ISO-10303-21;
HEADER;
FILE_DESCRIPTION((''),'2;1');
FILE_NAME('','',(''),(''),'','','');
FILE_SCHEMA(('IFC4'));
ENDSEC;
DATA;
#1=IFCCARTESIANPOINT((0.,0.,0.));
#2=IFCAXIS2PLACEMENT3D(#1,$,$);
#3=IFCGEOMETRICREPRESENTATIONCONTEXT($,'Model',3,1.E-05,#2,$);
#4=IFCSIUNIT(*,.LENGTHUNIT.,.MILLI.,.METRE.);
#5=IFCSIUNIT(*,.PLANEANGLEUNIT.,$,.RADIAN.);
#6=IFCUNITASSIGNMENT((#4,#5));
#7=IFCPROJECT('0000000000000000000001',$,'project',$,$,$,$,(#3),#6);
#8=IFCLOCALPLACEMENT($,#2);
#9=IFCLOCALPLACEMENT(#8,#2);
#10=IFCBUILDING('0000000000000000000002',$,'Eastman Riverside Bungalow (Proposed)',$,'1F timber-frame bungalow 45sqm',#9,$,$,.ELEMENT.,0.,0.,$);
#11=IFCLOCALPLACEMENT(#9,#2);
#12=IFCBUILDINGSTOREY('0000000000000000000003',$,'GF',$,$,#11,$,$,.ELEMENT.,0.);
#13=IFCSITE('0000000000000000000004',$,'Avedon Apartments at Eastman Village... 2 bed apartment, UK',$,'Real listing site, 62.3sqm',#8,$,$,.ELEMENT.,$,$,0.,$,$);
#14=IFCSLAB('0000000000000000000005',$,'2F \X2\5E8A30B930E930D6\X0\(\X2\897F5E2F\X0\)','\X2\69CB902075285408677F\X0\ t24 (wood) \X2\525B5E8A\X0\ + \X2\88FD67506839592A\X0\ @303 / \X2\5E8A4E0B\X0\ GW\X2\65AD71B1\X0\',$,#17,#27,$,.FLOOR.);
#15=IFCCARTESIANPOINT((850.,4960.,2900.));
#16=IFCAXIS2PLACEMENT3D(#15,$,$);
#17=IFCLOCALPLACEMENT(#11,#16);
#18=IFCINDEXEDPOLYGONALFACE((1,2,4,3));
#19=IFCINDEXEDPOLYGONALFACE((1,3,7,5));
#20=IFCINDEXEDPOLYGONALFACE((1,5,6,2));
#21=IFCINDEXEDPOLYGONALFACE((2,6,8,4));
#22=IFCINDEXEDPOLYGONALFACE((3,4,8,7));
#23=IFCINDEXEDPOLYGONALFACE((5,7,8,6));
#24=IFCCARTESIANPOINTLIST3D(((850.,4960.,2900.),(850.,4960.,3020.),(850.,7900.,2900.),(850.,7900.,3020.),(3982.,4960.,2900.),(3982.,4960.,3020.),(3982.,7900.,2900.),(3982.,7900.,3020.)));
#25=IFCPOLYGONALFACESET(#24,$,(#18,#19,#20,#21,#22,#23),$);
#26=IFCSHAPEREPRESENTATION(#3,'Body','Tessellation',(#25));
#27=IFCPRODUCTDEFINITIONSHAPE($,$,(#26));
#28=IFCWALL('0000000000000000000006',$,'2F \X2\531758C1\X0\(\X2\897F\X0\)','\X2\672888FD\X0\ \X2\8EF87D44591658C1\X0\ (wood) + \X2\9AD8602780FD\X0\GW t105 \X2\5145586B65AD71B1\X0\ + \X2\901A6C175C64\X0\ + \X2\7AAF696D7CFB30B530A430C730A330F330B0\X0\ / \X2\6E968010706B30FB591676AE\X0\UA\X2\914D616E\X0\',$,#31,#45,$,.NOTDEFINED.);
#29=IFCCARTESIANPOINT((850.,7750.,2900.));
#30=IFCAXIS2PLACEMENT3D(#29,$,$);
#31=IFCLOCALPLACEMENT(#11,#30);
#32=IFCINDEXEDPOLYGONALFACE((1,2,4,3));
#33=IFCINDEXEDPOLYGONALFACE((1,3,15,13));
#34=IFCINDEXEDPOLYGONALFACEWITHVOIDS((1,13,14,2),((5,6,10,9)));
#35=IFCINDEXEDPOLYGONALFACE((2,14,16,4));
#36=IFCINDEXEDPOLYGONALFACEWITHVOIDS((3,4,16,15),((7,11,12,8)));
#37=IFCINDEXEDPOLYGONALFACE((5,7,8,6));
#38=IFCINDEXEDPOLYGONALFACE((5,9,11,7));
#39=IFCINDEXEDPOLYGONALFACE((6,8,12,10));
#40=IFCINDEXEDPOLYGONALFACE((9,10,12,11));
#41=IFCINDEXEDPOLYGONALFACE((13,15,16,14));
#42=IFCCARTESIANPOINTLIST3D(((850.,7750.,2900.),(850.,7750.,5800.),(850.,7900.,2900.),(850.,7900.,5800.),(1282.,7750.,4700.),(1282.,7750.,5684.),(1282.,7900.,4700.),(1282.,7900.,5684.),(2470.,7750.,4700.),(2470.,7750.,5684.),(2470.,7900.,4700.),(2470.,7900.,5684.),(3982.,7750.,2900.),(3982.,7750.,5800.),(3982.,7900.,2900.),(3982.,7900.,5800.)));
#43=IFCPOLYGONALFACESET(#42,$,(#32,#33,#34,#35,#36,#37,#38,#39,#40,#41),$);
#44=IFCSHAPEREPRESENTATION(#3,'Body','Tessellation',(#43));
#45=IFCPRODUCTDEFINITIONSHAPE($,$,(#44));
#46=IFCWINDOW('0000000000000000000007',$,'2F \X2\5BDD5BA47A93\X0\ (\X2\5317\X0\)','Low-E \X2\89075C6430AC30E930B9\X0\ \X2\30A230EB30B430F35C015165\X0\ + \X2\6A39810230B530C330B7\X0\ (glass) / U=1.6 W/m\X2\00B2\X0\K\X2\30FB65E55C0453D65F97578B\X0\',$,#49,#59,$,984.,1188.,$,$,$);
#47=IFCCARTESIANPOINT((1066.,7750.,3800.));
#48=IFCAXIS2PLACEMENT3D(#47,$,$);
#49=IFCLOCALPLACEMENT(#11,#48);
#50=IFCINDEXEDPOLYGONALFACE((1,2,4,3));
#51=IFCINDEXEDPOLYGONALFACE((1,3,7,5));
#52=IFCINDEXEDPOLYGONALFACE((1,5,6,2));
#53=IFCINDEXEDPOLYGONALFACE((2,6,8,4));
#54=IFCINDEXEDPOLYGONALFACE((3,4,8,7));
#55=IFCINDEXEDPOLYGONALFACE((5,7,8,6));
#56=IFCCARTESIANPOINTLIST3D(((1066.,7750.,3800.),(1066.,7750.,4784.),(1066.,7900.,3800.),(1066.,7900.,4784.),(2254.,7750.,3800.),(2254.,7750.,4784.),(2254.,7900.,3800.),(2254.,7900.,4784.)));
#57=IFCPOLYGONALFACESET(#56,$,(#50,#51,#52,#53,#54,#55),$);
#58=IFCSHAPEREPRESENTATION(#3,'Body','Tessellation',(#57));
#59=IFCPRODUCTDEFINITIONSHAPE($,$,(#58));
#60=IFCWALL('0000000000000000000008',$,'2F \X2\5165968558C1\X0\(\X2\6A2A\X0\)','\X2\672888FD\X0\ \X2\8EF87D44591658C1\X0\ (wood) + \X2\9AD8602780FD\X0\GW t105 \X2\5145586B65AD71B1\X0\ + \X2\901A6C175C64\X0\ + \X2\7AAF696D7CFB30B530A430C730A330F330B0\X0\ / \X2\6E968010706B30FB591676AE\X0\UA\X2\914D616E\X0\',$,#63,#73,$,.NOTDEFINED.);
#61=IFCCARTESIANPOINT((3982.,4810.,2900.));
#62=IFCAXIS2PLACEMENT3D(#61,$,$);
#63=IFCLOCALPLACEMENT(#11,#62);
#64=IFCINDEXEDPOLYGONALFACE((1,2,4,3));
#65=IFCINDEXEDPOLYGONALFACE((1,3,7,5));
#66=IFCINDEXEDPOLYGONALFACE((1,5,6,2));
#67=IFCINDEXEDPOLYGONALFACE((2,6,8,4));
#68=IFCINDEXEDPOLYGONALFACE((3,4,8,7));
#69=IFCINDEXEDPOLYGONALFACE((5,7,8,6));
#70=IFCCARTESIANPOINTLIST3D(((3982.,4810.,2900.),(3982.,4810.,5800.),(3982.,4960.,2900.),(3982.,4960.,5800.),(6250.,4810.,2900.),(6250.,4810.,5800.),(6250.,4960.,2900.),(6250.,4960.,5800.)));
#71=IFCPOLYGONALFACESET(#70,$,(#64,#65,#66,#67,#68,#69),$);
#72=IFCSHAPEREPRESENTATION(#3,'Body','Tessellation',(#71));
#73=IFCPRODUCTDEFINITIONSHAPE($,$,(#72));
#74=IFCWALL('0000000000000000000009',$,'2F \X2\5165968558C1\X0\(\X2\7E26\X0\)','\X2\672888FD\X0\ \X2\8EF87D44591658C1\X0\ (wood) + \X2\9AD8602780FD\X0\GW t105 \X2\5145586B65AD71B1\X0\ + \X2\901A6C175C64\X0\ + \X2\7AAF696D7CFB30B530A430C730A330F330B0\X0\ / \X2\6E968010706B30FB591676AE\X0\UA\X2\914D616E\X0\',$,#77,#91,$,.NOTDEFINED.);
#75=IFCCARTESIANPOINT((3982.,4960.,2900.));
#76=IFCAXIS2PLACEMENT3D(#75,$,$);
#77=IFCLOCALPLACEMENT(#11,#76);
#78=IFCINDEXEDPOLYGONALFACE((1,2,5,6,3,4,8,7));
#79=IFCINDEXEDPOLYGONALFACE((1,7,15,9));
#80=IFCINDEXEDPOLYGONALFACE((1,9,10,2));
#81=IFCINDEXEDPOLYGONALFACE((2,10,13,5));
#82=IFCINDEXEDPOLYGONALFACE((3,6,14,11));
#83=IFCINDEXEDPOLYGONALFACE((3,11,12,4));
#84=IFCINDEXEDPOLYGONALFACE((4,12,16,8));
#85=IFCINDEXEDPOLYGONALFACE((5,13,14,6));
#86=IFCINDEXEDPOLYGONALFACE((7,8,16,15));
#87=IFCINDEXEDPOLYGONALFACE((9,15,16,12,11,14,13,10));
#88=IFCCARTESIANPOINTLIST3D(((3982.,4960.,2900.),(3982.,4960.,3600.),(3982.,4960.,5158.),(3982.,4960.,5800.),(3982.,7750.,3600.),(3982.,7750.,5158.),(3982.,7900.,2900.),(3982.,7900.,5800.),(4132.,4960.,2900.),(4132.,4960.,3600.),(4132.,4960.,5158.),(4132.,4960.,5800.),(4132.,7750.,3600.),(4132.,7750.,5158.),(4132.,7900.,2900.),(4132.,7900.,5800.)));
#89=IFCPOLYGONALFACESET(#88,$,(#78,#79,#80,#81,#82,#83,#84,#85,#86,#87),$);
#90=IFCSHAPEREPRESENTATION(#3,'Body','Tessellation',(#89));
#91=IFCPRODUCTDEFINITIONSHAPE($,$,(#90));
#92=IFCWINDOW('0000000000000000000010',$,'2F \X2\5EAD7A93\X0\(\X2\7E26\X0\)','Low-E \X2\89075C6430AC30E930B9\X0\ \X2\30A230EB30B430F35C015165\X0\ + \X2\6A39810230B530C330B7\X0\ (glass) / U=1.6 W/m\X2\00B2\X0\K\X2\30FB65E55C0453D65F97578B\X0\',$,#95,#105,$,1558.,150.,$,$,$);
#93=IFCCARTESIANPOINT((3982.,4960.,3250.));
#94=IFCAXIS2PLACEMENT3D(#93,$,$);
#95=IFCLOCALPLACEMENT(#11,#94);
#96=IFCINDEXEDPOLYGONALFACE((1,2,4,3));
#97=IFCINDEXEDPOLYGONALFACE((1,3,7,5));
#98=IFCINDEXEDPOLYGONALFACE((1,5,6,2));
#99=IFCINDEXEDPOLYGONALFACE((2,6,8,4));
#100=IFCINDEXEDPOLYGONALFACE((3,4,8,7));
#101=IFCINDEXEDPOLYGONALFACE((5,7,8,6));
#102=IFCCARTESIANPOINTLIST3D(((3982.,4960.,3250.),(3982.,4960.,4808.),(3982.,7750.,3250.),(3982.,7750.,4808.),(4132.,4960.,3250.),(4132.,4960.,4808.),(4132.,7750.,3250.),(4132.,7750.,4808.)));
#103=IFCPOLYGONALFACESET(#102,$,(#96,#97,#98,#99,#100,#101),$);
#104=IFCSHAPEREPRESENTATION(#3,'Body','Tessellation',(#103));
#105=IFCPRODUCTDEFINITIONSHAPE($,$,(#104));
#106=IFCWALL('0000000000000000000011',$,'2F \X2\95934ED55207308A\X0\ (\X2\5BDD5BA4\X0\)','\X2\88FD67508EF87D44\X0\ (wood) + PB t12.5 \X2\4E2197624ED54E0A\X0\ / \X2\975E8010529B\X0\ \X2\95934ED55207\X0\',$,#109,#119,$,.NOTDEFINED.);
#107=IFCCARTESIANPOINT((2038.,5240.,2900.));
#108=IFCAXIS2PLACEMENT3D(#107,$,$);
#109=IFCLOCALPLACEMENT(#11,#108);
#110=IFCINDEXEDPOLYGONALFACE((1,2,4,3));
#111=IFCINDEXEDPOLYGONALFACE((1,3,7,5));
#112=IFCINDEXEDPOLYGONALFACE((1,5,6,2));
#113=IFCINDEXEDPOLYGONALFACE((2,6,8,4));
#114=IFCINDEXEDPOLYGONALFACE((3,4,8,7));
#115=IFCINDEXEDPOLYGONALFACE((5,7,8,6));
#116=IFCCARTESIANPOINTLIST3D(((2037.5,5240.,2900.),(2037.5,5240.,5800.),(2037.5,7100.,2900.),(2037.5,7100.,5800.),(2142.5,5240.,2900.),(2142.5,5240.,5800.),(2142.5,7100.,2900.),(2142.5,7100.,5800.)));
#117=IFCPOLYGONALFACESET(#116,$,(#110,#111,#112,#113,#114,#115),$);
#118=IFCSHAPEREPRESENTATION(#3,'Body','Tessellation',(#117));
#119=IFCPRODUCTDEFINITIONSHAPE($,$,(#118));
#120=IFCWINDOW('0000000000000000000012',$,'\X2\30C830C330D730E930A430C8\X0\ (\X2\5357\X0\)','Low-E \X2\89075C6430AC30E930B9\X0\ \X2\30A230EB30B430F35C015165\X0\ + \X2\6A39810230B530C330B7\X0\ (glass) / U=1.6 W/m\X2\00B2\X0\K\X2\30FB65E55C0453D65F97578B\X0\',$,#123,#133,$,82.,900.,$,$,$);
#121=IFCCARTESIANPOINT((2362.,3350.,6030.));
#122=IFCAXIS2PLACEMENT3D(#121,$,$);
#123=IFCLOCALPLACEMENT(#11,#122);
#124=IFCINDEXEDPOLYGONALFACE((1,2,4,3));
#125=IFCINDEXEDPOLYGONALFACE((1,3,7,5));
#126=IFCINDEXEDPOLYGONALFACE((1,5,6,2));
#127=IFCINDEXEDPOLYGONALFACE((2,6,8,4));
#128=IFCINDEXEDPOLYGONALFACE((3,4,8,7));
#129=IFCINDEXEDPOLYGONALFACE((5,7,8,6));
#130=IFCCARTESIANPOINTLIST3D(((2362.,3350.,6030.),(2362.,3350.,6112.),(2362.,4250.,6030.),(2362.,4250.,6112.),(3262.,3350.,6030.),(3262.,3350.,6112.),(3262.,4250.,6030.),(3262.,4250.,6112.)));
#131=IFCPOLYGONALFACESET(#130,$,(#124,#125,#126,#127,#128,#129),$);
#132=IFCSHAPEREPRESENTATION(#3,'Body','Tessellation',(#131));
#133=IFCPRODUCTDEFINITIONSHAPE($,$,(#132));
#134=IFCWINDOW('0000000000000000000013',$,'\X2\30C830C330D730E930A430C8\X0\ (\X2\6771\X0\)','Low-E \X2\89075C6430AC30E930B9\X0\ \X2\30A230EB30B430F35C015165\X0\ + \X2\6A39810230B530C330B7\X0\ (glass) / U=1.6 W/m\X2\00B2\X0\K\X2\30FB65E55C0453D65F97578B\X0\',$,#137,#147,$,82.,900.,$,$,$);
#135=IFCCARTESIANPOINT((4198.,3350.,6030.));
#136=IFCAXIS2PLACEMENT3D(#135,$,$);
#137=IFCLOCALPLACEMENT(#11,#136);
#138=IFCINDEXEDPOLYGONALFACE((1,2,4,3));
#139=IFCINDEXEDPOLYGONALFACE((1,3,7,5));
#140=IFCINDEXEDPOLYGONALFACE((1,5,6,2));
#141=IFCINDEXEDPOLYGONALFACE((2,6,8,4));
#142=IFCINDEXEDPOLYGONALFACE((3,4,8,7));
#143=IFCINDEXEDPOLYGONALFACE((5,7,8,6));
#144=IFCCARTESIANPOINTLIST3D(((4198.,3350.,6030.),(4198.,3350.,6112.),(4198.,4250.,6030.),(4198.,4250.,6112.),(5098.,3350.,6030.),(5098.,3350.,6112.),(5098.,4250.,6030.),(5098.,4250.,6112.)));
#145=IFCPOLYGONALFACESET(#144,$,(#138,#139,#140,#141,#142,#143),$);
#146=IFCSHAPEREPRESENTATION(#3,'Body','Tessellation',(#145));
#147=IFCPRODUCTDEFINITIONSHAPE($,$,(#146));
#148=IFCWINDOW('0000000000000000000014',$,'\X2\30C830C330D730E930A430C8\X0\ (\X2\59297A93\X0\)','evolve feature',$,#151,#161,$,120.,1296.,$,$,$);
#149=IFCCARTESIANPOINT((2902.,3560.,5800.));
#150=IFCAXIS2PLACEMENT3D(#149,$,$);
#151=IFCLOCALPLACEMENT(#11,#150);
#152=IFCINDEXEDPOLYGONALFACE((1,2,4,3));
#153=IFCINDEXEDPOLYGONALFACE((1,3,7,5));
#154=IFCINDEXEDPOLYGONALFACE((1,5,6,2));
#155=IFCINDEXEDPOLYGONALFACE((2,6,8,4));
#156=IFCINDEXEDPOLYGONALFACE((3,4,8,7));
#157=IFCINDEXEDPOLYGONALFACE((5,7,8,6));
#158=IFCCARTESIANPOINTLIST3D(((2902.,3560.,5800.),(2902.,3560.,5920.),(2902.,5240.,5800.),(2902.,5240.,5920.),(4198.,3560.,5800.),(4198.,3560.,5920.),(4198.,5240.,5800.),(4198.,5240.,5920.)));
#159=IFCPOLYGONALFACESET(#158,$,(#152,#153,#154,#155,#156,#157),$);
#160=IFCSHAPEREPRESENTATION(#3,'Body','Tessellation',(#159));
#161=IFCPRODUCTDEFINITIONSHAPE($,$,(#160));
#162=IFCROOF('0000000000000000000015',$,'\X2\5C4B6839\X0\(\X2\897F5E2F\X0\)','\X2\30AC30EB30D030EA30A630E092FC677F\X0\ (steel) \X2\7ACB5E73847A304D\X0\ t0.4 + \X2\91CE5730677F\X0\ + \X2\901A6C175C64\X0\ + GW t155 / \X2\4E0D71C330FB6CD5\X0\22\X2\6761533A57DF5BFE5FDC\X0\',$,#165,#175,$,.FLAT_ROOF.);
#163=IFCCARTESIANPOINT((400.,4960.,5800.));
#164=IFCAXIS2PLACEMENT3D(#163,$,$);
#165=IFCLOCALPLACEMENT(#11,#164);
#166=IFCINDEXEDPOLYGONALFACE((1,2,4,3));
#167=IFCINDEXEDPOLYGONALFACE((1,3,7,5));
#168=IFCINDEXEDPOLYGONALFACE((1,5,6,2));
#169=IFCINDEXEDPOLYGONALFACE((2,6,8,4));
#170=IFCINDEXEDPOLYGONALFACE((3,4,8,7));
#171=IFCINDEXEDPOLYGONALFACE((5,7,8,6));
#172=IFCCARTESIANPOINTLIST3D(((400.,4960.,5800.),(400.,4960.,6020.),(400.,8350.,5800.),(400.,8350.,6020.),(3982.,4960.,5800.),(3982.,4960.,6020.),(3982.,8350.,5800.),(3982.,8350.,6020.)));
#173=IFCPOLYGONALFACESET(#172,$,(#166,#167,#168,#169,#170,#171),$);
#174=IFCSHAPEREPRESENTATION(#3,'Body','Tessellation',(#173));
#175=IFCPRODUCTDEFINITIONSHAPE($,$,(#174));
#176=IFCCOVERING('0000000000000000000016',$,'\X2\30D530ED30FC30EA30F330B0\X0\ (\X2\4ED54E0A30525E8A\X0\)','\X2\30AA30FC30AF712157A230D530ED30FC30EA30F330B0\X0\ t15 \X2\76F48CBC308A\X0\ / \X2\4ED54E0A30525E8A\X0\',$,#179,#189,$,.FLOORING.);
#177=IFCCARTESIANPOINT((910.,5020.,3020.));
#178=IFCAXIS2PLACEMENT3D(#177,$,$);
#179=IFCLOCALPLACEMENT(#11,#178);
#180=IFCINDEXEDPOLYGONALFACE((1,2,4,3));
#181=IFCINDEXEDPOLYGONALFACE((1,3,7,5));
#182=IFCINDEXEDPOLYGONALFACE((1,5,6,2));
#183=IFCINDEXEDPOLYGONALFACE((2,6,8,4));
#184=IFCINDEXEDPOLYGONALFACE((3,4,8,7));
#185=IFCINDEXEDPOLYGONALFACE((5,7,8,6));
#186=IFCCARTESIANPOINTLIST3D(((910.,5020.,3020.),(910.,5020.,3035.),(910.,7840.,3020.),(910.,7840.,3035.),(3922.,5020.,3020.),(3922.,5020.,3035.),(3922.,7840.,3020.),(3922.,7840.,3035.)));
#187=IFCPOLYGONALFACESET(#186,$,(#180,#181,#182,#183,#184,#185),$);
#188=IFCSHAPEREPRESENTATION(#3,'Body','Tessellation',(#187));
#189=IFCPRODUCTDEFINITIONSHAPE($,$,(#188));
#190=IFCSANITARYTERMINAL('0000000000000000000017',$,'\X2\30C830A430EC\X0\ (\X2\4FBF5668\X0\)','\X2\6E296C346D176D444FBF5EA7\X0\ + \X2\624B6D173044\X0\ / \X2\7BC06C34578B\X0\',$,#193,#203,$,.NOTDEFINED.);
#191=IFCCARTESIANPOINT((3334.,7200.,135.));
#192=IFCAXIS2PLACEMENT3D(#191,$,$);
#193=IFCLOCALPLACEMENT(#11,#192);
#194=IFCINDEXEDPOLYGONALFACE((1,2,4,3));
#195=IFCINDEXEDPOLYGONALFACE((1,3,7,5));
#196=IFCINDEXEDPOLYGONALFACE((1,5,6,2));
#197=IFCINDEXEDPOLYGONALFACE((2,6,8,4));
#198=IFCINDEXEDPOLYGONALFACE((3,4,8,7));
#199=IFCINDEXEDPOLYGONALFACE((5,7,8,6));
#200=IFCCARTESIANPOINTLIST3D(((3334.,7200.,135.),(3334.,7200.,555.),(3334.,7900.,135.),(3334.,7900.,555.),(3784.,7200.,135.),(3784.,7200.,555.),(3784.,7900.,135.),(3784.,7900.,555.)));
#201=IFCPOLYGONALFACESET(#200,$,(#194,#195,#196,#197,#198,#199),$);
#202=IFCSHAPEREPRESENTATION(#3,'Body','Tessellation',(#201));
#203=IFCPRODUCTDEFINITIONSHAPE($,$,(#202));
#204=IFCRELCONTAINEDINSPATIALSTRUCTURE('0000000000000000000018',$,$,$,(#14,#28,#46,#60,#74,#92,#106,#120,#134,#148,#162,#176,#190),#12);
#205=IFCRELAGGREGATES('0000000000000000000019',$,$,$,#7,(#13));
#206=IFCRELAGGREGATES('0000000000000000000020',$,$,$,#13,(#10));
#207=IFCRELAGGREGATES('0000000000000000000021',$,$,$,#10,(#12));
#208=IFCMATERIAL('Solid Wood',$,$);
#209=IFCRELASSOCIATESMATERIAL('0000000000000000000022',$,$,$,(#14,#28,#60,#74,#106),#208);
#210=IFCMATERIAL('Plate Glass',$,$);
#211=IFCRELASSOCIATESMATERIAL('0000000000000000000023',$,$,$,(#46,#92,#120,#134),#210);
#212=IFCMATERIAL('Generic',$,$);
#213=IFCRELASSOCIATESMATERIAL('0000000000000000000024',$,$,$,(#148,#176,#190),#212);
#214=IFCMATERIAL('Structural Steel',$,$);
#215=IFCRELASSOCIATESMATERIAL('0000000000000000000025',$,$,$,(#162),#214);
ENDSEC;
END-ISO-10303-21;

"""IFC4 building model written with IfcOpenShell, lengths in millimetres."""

from ifc_helpers import new_model, si_unit, frame, frame_2d, origin, place, context, project, spatial, rectangle, extrude, material, element, fill, save


model = new_model("IFC4")

# Units and contexts
model_context = context("Model", 3, precision=1e-05, world=origin())
ifc_project = project(units=[si_unit("LENGTHUNIT", "METRE", prefix="MILLI"), si_unit("PLANEANGLEUNIT", "RADIAN")], contexts=[model_context])

# Site, building, storey
site_placement = place(None, origin())
site = spatial("IfcSite", under=ifc_project, at=site_placement, Name="Avedon Apartments at Eastman Village... 2 bed apartment, UK", ObjectType="Real listing site, 62.3sqm", CompositionType="ELEMENT", RefElevation=0.0)
building_placement = place(site_placement, origin())
building = spatial("IfcBuilding", under=site, at=building_placement, Name="Eastman Riverside Bungalow (Proposed)", ObjectType="1F timber-frame bungalow 45sqm", CompositionType="ELEMENT", ElevationOfRefHeight=0.0, ElevationOfTerrain=0.0)
storey_placement = place(building_placement, origin())
storey = spatial("IfcBuildingStorey", under=building, at=storey_placement, Name="GF", CompositionType="ELEMENT", Elevation=0.0)

# Slab
ifc_material_1 = material(Name="Solid Wood")
slab_placement = place(storey_placement, frame((850.0, 4960.0, 2900.0)))
element("IfcSlab", 1, at=slab_placement, inside=storey, material=ifc_material_1, Name="2F 床スラブ(西帯)", Description="構造用合板 t24 (wood) 剛床 + 製材根太 @303 / 床下 GW断熱", PredefinedType="FLOOR", context=model_context, shape_type="SweptSolid", body=[
    extrude(rectangle(XDim=3132.0, YDim=2940.0, at=frame_2d((1566.0, 1470.0))), frame((850.0, 4960.0, 2900.0)), (0.0, 0.0, 1.0), 120.0),
])

# Wall, opening, window
wall_1_placement = place(storey_placement, frame((850.0, 7750.0, 2900.0)))
wall_1 = element("IfcWall", 2, at=wall_1_placement, inside=storey, material=ifc_material_1, Name="2F 北壁(西)", Description="木製 軸組外壁 (wood) + 高性能GW t105 充填断熱 + 通気層 + 窯業系サイディング / 準耐火・外皮UA配慮", PredefinedType="NOTDEFINED", context=model_context, shape_type="SweptSolid", body=[
    extrude(rectangle(XDim=3132.0, YDim=150.0, at=frame_2d((1566.0, 75.0))), frame((850.0, 7750.0, 2900.0)), (0.0, 0.0, 1.0), 2900.0),
])
opening_1_placement = place(storey_placement, frame((1066.0, 7750.0, 3800.0)))
opening_1 = element("IfcOpeningElement", 3, at=opening_1_placement, cuts=wall_1, PredefinedType="NOTDEFINED", context=model_context, shape_type="SweptSolid", body=[
    extrude(rectangle(XDim=1188.0, YDim=150.0, at=frame_2d((594.0, 75.0))), frame((1066.0, 7750.0, 3800.0)), (0.0, 0.0, 1.0), 984.0),
])
ifc_material_2 = material(Name="Plate Glass")
window_1_placement = place(storey_placement, frame((1066.0, 7750.0, 3800.0)))
window_1 = element("IfcWindow", 4, at=window_1_placement, inside=storey, material=ifc_material_2, Name="2F 寝室窓 (北)", Description="Low-E 複層ガラス アルゴン封入 + 樹脂サッシ (glass) / U=1.6 W/m²K・日射取得型", OverallHeight=984.0, OverallWidth=1188.0, context=model_context, shape_type="SweptSolid", body=[
    extrude(rectangle(XDim=1188.0, YDim=150.0, at=frame_2d((594.0, 75.0))), frame((1066.0, 7750.0, 3800.0)), (0.0, 0.0, 1.0), 984.0),
])
fill(opening_1, window_1)

# Wall
wall_2_placement = place(storey_placement, frame((3982.0, 4810.0, 2900.0)))
element("IfcWall", 5, at=wall_2_placement, inside=storey, material=ifc_material_1, Name="2F 入隅壁(横)", Description="木製 軸組外壁 (wood) + 高性能GW t105 充填断熱 + 通気層 + 窯業系サイディング / 準耐火・外皮UA配慮", PredefinedType="NOTDEFINED", context=model_context, shape_type="SweptSolid", body=[
    extrude(rectangle(XDim=2268.0, YDim=150.0, at=frame_2d((1134.0, 75.0))), frame((3982.0, 4810.0, 2900.0)), (0.0, 0.0, 1.0), 2900.0),
])

# Wall, opening, window
wall_3_placement = place(storey_placement, frame((3982.0, 4960.0, 2900.0)))
wall_3 = element("IfcWall", 6, at=wall_3_placement, inside=storey, material=ifc_material_1, Name="2F 入隅壁(縦)", Description="木製 軸組外壁 (wood) + 高性能GW t105 充填断熱 + 通気層 + 窯業系サイディング / 準耐火・外皮UA配慮", PredefinedType="NOTDEFINED", context=model_context, shape_type="SweptSolid", body=[
    extrude(rectangle(XDim=150.0, YDim=2940.0, at=frame_2d((75.0, 1470.0))), frame((3982.0, 4960.0, 2900.0)), (0.0, 0.0, 1.0), 2900.0),
])
opening_2_placement = place(storey_placement, frame((3982.0, 4960.0, 3250.0)))
opening_2 = element("IfcOpeningElement", 7, at=opening_2_placement, cuts=wall_3, PredefinedType="NOTDEFINED", context=model_context, shape_type="SweptSolid", body=[
    extrude(rectangle(XDim=150.0, YDim=2790.0, at=frame_2d((75.0, 1395.0))), frame((3982.0, 4960.0, 3250.0)), (0.0, 0.0, 1.0), 1558.0),
])
window_2_placement = place(storey_placement, frame((3982.0, 4960.0, 3250.0)))
window_2 = element("IfcWindow", 8, at=window_2_placement, inside=storey, material=ifc_material_2, Name="2F 庭窓(縦)", Description="Low-E 複層ガラス アルゴン封入 + 樹脂サッシ (glass) / U=1.6 W/m²K・日射取得型", OverallHeight=1558.0, OverallWidth=150.0, context=model_context, shape_type="SweptSolid", body=[
    extrude(rectangle(XDim=150.0, YDim=2790.0, at=frame_2d((75.0, 1395.0))), frame((3982.0, 4960.0, 3250.0)), (0.0, 0.0, 1.0), 1558.0),
])
fill(opening_2, window_2)

# Wall
wall_4_placement = place(storey_placement, frame((2038.0, 5240.0, 2900.0)))
element("IfcWall", 9, at=wall_4_placement, inside=storey, material=ifc_material_1, Name="2F 間仕切り (寝室)", Description="製材軸組 (wood) + PB t12.5 両面仕上 / 非耐力 間仕切", PredefinedType="NOTDEFINED", context=model_context, shape_type="SweptSolid", body=[
    extrude(rectangle(XDim=105.0, YDim=1860.0, at=frame_2d((52.0, 930.0))), frame((2038.0, 5240.0, 2900.0)), (0.0, 0.0, 1.0), 2900.0),
])

# Windows
window_3_placement = place(storey_placement, frame((2362.0, 3350.0, 6030.0)))
element("IfcWindow", 10, at=window_3_placement, inside=storey, material=ifc_material_2, Name="トップライト (南)", Description="Low-E 複層ガラス アルゴン封入 + 樹脂サッシ (glass) / U=1.6 W/m²K・日射取得型", OverallHeight=82.0, OverallWidth=900.0, context=model_context, shape_type="SweptSolid", body=[
    extrude(rectangle(XDim=900.0, YDim=900.0, at=frame_2d((450.0, 450.0))), frame((2362.0, 3350.0, 6030.0)), (0.0, 0.0, 1.0), 82.0),
])
window_4_placement = place(storey_placement, frame((4198.0, 3350.0, 6030.0)))
element("IfcWindow", 11, at=window_4_placement, inside=storey, material=ifc_material_2, Name="トップライト (東)", Description="Low-E 複層ガラス アルゴン封入 + 樹脂サッシ (glass) / U=1.6 W/m²K・日射取得型", OverallHeight=82.0, OverallWidth=900.0, context=model_context, shape_type="SweptSolid", body=[
    extrude(rectangle(XDim=900.0, YDim=900.0, at=frame_2d((450.0, 450.0))), frame((4198.0, 3350.0, 6030.0)), (0.0, 0.0, 1.0), 82.0),
])
ifc_material_3 = material(Name="Generic")
window_5_placement = place(storey_placement, frame((2902.0, 3560.0, 5800.0)))
element("IfcWindow", 12, at=window_5_placement, inside=storey, material=ifc_material_3, Name="トップライト (天窓)", Description="evolve feature", OverallHeight=120.0, OverallWidth=1296.0, context=model_context, shape_type="SweptSolid", body=[
    extrude(rectangle(XDim=1296.0, YDim=1680.0, at=frame_2d((648.0, 840.0))), frame((2902.0, 3560.0, 5800.0)), (0.0, 0.0, 1.0), 120.0),
])

# Roof
ifc_material_4 = material(Name="Structural Steel")
for number, where, name in (
    (13, (400.0, 4960.0, 5800.0), "屋根(西帯)"),
):
    element("IfcRoof", number, at=place(storey_placement, frame(where)), inside=storey, material=ifc_material_4, Name=name, Description="ガルバリウム鋼板 (steel) 立平葺き t0.4 + 野地板 + 通気層 + GW t155 / 不燃・法22条区域対応", PredefinedType="FLAT_ROOF", context=model_context, shape_type="SweptSolid", body=[
        extrude(rectangle(XDim=3582.0, YDim=3390.0, at=frame_2d((1791.0, 1695.0))), frame((400.0, 4960.0, 5800.0)), (0.0, 0.0, 1.0), 220.0),
    ])

# Covering
covering_placement = place(storey_placement, frame((910.0, 5020.0, 3020.0)))
element("IfcCovering", 14, at=covering_placement, inside=storey, material=ifc_material_3, Name="フローリング (仕上げ床)", Description="オーク無垢フローリング t15 直貼り / 仕上げ床", PredefinedType="FLOORING", context=model_context, shape_type="SweptSolid", body=[
    extrude(rectangle(XDim=3012.0, YDim=2820.0, at=frame_2d((1506.0, 1410.0))), frame((910.0, 5020.0, 3020.0)), (0.0, 0.0, 1.0), 15.0),
])

# Sanitary terminal
sanitary_terminal_placement = place(storey_placement, frame((3334.0, 7200.0, 135.0)))
element("IfcSanitaryTerminal", 15, at=sanitary_terminal_placement, inside=storey, material=ifc_material_3, Name="トイレ (便器)", Description="温水洗浄便座 + 手洗い / 節水型", PredefinedType="NOTDEFINED", context=model_context, shape_type="SweptSolid", body=[
    extrude(rectangle(XDim=450.0, YDim=700.0, at=frame_2d((225.0, 350.0))), frame((3334.0, 7200.0, 135.0)), (0.0, 0.0, 1.0), 420.0),
])

save(model, "model.ifc")
